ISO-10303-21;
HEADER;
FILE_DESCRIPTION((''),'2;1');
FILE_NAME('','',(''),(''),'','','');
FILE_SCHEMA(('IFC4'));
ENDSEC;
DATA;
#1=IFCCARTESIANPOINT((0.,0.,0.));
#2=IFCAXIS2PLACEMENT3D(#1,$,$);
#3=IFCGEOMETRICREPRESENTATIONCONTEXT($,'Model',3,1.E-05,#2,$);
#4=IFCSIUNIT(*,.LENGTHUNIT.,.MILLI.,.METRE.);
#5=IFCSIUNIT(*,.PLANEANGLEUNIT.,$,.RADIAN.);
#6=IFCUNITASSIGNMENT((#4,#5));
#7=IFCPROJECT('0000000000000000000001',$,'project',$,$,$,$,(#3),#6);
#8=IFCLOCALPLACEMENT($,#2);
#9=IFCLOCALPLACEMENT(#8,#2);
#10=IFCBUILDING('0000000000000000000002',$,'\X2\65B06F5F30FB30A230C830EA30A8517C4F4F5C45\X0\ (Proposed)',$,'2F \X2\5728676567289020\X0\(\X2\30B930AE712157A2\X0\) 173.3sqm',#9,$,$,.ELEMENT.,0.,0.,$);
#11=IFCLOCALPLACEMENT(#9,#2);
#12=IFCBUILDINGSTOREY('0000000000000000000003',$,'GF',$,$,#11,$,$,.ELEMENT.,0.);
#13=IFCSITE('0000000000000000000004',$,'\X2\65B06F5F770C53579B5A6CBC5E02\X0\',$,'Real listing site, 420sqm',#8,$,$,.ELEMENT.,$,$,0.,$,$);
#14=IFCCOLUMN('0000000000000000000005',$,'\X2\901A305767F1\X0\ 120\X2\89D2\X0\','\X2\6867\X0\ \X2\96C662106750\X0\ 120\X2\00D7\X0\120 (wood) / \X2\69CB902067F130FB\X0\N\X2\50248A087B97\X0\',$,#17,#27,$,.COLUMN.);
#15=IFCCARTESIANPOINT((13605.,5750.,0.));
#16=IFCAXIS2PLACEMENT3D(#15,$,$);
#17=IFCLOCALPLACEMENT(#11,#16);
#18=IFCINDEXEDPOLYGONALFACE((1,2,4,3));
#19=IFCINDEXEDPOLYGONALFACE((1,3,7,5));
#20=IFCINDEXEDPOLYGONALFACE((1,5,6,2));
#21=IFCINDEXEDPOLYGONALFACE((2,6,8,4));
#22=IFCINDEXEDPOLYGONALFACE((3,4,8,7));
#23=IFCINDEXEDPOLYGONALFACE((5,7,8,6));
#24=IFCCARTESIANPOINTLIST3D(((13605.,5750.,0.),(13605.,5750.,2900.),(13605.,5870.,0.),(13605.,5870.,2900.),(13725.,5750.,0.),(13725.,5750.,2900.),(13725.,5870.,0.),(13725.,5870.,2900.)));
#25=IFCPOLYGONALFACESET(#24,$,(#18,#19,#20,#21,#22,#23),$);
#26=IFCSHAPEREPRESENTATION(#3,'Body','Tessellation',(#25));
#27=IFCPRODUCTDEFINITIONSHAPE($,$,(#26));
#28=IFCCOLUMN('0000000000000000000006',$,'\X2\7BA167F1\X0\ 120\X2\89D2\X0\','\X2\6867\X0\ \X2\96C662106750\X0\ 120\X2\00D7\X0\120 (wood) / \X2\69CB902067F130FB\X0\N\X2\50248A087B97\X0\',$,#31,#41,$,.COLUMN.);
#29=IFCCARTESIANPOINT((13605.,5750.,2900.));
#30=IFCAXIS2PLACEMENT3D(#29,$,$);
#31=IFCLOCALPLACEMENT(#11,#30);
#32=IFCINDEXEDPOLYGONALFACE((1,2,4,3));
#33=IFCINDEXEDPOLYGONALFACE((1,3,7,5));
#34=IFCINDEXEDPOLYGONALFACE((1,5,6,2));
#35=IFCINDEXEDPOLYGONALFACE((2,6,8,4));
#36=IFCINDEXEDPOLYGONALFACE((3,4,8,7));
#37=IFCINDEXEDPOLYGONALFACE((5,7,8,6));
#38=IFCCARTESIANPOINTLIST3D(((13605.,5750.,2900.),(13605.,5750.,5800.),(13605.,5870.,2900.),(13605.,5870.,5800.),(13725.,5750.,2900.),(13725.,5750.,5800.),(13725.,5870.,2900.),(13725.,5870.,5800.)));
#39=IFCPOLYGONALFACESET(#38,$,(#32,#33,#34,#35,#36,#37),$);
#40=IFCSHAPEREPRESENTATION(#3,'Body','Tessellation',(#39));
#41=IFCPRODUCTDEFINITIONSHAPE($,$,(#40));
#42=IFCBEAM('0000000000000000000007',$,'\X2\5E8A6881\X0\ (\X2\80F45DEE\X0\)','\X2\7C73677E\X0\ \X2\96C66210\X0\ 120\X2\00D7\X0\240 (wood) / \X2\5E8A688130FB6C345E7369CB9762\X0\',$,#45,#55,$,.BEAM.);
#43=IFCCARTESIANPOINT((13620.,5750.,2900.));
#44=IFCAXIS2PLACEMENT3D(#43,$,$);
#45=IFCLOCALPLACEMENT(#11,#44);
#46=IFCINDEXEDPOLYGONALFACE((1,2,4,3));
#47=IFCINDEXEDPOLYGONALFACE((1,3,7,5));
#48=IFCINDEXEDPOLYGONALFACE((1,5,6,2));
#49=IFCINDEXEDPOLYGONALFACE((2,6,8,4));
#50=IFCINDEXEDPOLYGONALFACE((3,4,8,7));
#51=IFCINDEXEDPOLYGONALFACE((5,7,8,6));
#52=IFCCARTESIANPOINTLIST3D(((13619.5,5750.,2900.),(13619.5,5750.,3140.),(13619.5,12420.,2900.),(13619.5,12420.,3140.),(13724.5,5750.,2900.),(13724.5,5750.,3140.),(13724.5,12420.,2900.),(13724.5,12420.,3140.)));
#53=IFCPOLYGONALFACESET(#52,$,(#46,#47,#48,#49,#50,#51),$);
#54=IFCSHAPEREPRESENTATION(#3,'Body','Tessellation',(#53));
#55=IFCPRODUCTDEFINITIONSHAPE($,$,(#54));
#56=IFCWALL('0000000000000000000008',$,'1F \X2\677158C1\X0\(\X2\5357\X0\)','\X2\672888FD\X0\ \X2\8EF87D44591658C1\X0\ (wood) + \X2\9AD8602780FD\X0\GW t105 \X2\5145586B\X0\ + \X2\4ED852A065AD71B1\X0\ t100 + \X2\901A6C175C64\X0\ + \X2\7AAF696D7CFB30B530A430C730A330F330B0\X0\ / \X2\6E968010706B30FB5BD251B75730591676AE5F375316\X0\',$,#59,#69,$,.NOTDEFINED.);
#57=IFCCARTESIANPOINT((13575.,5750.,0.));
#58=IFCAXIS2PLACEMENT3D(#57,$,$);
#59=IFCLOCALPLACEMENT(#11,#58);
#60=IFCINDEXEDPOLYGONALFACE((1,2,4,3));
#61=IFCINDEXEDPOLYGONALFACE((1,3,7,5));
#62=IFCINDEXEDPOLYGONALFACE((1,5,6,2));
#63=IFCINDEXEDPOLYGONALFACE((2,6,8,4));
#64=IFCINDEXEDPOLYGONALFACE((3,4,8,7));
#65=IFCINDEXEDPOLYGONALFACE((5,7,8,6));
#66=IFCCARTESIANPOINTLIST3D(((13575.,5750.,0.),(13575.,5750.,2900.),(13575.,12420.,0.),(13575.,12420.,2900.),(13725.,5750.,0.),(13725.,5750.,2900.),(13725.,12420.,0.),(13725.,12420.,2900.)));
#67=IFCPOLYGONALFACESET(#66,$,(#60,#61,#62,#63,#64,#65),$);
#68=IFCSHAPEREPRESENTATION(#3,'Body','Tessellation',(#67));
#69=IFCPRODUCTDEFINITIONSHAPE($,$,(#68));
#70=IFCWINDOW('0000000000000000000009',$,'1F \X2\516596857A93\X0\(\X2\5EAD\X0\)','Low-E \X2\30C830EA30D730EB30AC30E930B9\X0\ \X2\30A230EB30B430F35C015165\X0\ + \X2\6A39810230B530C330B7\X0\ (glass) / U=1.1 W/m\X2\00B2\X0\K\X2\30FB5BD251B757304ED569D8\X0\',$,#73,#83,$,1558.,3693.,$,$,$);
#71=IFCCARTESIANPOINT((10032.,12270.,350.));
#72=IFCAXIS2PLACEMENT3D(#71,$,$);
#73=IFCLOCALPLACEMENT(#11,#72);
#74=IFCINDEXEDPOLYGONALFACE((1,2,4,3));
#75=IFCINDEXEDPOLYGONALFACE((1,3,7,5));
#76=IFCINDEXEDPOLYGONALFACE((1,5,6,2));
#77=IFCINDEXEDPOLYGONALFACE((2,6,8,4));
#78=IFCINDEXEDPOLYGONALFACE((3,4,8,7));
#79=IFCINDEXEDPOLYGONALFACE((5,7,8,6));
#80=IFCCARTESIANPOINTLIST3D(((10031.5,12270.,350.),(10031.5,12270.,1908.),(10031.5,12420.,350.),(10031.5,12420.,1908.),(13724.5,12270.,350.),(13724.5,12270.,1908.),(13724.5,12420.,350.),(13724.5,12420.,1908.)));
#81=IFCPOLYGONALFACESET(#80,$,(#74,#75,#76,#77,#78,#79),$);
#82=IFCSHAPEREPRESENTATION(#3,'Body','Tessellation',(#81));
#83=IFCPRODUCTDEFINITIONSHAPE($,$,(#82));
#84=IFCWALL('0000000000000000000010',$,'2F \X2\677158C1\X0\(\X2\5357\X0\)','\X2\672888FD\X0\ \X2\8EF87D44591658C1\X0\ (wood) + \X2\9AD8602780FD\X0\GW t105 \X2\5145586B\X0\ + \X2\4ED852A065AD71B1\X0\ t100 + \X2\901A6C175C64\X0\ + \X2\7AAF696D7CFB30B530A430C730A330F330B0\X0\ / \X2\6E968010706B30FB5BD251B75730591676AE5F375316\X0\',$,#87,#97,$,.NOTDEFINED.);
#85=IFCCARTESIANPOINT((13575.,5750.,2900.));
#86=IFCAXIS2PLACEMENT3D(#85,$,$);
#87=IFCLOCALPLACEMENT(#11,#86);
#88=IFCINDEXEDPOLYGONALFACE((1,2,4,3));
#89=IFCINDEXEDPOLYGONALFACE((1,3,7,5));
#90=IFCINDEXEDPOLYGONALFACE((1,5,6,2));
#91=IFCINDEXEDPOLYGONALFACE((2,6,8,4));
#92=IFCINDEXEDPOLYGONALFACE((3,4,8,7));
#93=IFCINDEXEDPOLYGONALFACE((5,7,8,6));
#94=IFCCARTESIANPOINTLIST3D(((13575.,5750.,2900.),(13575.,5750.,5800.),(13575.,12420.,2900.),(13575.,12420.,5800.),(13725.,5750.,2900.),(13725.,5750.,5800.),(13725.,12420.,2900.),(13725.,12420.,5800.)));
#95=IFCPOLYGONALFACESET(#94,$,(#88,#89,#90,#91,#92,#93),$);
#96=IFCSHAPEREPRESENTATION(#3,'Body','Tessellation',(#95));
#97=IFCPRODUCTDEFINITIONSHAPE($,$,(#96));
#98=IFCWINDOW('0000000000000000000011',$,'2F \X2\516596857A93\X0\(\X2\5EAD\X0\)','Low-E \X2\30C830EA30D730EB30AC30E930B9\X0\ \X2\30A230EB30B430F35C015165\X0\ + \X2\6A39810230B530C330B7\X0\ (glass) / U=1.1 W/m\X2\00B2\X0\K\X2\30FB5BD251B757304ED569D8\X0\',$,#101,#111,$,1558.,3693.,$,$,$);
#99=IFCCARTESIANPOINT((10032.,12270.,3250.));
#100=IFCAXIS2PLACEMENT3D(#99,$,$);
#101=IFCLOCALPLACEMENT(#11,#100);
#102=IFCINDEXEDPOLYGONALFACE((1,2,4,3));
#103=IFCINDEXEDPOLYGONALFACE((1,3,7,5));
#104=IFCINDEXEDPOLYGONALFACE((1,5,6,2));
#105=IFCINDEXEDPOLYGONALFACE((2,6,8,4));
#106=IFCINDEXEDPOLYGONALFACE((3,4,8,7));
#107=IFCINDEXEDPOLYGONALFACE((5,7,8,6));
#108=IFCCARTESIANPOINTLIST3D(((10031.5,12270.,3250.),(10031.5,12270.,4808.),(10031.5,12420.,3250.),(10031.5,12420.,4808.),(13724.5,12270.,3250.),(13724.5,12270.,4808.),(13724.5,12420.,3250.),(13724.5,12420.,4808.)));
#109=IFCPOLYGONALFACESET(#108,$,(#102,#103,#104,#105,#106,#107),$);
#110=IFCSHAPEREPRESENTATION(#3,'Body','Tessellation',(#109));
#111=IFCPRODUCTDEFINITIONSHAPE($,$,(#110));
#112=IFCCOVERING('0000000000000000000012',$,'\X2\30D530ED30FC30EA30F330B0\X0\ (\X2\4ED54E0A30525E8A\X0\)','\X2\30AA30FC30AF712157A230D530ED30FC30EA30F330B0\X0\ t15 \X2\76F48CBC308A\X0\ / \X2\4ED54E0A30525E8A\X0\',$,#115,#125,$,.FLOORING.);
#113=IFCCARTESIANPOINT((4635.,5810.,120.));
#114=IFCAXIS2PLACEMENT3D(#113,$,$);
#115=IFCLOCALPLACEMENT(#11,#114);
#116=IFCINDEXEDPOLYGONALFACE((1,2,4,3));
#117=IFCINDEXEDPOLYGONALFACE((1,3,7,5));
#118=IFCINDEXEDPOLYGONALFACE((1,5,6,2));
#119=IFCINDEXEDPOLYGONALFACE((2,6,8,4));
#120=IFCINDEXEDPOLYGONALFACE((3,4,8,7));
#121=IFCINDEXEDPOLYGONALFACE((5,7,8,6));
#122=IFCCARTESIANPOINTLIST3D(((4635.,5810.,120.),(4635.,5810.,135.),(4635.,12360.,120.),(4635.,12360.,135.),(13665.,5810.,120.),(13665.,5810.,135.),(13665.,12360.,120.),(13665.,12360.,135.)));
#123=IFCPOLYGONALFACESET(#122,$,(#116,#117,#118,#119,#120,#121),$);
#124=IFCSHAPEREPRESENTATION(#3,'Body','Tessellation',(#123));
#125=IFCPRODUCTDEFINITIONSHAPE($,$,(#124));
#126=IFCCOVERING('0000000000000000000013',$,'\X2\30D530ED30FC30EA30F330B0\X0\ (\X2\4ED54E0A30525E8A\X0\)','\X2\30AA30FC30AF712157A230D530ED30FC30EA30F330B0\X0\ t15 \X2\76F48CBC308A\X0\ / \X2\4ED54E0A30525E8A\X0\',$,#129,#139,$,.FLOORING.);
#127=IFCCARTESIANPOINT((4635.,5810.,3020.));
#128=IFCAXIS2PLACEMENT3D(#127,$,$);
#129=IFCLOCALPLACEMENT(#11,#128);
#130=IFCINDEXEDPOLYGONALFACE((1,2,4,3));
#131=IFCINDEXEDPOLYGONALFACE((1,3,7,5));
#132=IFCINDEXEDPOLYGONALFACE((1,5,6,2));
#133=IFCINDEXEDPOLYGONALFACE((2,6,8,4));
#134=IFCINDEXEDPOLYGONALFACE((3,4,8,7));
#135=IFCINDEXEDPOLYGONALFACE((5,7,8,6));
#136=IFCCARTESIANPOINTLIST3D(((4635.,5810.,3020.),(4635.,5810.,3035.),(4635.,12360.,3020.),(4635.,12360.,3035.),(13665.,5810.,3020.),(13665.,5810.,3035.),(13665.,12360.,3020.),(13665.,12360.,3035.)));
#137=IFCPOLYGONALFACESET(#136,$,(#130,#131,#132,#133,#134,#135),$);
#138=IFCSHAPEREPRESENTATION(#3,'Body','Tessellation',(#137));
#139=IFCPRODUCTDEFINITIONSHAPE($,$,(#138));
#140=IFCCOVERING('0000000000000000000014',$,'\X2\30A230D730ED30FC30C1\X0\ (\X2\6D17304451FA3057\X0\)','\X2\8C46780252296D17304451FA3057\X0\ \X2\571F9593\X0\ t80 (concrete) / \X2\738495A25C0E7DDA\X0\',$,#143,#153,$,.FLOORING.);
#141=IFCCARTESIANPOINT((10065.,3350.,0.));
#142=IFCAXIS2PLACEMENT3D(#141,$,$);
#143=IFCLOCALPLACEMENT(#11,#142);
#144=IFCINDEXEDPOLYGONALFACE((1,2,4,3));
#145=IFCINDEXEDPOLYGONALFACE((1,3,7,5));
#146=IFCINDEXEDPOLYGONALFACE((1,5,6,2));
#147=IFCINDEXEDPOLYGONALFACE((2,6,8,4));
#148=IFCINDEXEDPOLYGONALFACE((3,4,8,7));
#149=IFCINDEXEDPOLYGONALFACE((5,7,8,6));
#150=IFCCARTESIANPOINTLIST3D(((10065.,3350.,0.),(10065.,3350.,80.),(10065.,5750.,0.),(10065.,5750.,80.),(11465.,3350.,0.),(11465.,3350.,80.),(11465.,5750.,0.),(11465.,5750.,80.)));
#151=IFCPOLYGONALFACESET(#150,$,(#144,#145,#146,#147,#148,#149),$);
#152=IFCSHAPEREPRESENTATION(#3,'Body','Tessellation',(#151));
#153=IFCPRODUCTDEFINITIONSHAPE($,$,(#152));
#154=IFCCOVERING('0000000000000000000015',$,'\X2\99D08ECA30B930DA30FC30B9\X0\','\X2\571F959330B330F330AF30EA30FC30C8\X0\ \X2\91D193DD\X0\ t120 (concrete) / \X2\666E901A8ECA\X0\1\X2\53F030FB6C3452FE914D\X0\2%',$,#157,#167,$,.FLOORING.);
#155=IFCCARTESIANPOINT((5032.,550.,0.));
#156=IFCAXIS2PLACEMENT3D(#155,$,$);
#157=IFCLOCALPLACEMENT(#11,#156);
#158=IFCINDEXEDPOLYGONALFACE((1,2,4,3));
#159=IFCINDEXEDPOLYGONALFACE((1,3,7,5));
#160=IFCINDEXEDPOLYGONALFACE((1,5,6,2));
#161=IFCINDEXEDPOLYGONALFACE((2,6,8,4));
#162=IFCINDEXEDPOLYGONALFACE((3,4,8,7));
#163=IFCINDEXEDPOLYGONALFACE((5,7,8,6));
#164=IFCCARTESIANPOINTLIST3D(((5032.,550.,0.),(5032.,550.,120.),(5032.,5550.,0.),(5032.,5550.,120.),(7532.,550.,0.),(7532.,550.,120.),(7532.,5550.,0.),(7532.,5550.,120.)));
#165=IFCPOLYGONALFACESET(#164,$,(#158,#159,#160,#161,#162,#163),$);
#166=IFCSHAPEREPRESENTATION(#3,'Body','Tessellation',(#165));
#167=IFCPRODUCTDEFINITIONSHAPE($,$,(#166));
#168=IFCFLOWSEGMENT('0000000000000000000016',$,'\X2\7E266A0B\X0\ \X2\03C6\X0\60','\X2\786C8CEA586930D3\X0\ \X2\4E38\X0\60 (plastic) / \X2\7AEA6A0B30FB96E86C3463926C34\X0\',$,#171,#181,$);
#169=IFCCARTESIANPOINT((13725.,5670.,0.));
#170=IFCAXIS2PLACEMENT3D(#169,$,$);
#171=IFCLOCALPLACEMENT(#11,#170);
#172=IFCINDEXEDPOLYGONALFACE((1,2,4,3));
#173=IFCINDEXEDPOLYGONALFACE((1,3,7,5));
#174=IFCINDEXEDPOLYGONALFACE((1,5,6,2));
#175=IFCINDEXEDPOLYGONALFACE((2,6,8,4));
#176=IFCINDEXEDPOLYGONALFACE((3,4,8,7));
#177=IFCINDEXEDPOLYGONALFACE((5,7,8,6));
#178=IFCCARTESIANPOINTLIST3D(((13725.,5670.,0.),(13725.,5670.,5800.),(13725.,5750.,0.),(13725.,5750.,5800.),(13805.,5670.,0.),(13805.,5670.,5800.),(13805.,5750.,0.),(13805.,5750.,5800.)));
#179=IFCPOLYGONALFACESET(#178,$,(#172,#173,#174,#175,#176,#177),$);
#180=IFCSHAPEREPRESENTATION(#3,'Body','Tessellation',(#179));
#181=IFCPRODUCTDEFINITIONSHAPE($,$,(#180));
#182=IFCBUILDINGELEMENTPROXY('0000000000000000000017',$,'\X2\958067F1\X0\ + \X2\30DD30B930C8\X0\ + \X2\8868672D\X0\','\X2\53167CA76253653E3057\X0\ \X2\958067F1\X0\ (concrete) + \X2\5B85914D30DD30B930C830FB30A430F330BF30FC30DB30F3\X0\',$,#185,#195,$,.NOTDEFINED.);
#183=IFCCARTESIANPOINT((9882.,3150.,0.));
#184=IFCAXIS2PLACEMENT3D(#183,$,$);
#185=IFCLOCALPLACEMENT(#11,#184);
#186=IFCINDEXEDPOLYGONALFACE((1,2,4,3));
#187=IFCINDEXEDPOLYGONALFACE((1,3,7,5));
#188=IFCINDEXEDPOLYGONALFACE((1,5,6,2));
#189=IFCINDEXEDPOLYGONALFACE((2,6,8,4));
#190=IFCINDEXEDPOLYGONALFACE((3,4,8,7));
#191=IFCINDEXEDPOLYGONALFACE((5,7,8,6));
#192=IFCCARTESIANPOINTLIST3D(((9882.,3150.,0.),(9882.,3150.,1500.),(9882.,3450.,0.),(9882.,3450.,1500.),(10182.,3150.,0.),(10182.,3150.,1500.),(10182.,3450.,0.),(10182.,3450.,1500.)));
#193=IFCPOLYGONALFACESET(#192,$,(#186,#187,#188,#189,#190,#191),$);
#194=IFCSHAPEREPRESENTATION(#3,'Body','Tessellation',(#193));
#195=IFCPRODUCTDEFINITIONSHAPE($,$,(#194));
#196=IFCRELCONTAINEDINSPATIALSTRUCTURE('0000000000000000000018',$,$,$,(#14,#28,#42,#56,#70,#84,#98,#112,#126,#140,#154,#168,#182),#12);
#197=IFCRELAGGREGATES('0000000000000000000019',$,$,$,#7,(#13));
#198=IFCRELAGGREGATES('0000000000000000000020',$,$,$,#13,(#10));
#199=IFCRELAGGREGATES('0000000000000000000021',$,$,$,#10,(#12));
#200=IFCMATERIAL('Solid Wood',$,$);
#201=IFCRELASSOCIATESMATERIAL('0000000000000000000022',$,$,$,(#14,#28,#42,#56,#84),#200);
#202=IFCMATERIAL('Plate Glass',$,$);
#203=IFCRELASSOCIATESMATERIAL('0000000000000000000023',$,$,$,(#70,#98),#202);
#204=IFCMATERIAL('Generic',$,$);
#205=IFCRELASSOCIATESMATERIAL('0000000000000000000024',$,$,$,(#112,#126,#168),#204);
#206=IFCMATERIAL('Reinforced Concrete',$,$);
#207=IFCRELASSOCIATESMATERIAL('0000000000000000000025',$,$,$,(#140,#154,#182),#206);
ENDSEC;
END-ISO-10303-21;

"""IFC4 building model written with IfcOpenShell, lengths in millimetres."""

from ifc_helpers import new_model, si_unit, frame, frame_2d, origin, place, context, project, spatial, rectangle, extrude, material, element, fill, save


model = new_model("IFC4")

# Units and contexts
model_context = context("Model", 3, precision=1e-05, world=origin())
ifc_project = project(units=[si_unit("LENGTHUNIT", "METRE", prefix="MILLI"), si_unit("PLANEANGLEUNIT", "RADIAN")], contexts=[model_context])

# Site, building, storey
site_placement = place(None, origin())
site = spatial("IfcSite", under=ifc_project, at=site_placement, Name="新潟県南魚沼市", ObjectType="Real listing site, 420sqm", CompositionType="ELEMENT", RefElevation=0.0)
building_placement = place(site_placement, origin())
building = spatial("IfcBuilding", under=site, at=building_placement, Name="新潟・アトリエ兼住居 (Proposed)", ObjectType="2F 在来木造(スギ無垢) 173.3sqm", CompositionType="ELEMENT", ElevationOfRefHeight=0.0, ElevationOfTerrain=0.0)
storey_placement = place(building_placement, origin())
storey = spatial("IfcBuildingStorey", under=building, at=storey_placement, Name="GF", CompositionType="ELEMENT", Elevation=0.0)

# Columns
ifc_material_1 = material(Name="Solid Wood")
column_1_placement = place(storey_placement, frame((13605.0, 5750.0, 0.0)))
element("IfcColumn", 1, at=column_1_placement, inside=storey, material=ifc_material_1, Name="通し柱 120角", Description="桧 集成材 120×120 (wood) / 構造柱・N値計算", PredefinedType="COLUMN", context=model_context, shape_type="SweptSolid", body=[
    extrude(rectangle(XDim=120.0, YDim=120.0, at=frame_2d((60.0, 60.0))), frame((13605.0, 5750.0, 0.0)), (0.0, 0.0, 1.0), 2900.0),
])
column_2_placement = place(storey_placement, frame((13605.0, 5750.0, 2900.0)))
element("IfcColumn", 2, at=column_2_placement, inside=storey, material=ifc_material_1, Name="管柱 120角", Description="桧 集成材 120×120 (wood) / 構造柱・N値計算", PredefinedType="COLUMN", context=model_context, shape_type="SweptSolid", body=[
    extrude(rectangle(XDim=120.0, YDim=120.0, at=frame_2d((60.0, 60.0))), frame((13605.0, 5750.0, 2900.0)), (0.0, 0.0, 1.0), 2900.0),
])

# Beam
beam_1_placement = place(storey_placement, frame((13620.0, 5750.0, 2900.0)))
element("IfcBeam", 3, at=beam_1_placement, inside=storey, material=ifc_material_1, Name="床梁 (胴差)", Description="米松 集成 120×240 (wood) / 床梁・水平構面", PredefinedType="BEAM", context=model_context, shape_type="SweptSolid", body=[
    extrude(rectangle(XDim=105.0, YDim=6670.0, at=frame_2d((52.0, 3335.0))), frame((13620.0, 5750.0, 2900.0)), (0.0, 0.0, 1.0), 240.0),
])

# Wall, opening, window
wall_1_placement = place(storey_placement, frame((13575.0, 5750.0, 0.0)))
wall_1 = element("IfcWall", 4, at=wall_1_placement, inside=storey, material=ifc_material_1, Name="1F 東壁(南)", Description="木製 軸組外壁 (wood) + 高性能GW t105 充填 + 付加断熱 t100 + 通気層 + 窯業系サイディング / 準耐火・寒冷地外皮強化", PredefinedType="NOTDEFINED", context=model_context, shape_type="SweptSolid", body=[
    extrude(rectangle(XDim=150.0, YDim=6670.0, at=frame_2d((75.0, 3335.0))), frame((13575.0, 5750.0, 0.0)), (0.0, 0.0, 1.0), 2900.0),
])
opening_1_placement = place(storey_placement, frame((10032.0, 12270.0, 350.0)))
opening_1 = element("IfcOpeningElement", 5, at=opening_1_placement, cuts=wall_1, PredefinedType="NOTDEFINED", context=model_context, shape_type="SweptSolid", body=[
    extrude(rectangle(XDim=3693.0, YDim=150.0, at=frame_2d((1846.0, 75.0))), frame((10032.0, 12270.0, 350.0)), (0.0, 0.0, 1.0), 1558.0),
])
ifc_material_2 = material(Name="Plate Glass")
window_1_placement = place(storey_placement, frame((10032.0, 12270.0, 350.0)))
window_1 = element("IfcWindow", 6, at=window_1_placement, inside=storey, material=ifc_material_2, Name="1F 入隅窓(庭)", Description="Low-E トリプルガラス アルゴン封入 + 樹脂サッシ (glass) / U=1.1 W/m²K・寒冷地仕様", OverallHeight=1558.0, OverallWidth=3693.0, context=model_context, shape_type="SweptSolid", body=[
    extrude(rectangle(XDim=3693.0, YDim=150.0, at=frame_2d((1846.0, 75.0))), frame((10032.0, 12270.0, 350.0)), (0.0, 0.0, 1.0), 1558.0),
])
fill(opening_1, window_1)

# Wall, opening, window
wall_2_placement = place(storey_placement, frame((13575.0, 5750.0, 2900.0)))
wall_2 = element("IfcWall", 7, at=wall_2_placement, inside=storey, material=ifc_material_1, Name="2F 東壁(南)", Description="木製 軸組外壁 (wood) + 高性能GW t105 充填 + 付加断熱 t100 + 通気層 + 窯業系サイディング / 準耐火・寒冷地外皮強化", PredefinedType="NOTDEFINED", context=model_context, shape_type="SweptSolid", body=[
    extrude(rectangle(XDim=150.0, YDim=6670.0, at=frame_2d((75.0, 3335.0))), frame((13575.0, 5750.0, 2900.0)), (0.0, 0.0, 1.0), 2900.0),
])
opening_2_placement = place(storey_placement, frame((10032.0, 12270.0, 3250.0)))
opening_2 = element("IfcOpeningElement", 8, at=opening_2_placement, cuts=wall_2, PredefinedType="NOTDEFINED", context=model_context, shape_type="SweptSolid", body=[
    extrude(rectangle(XDim=3693.0, YDim=150.0, at=frame_2d((1846.0, 75.0))), frame((10032.0, 12270.0, 3250.0)), (0.0, 0.0, 1.0), 1558.0),
])
window_2_placement = place(storey_placement, frame((10032.0, 12270.0, 3250.0)))
window_2 = element("IfcWindow", 9, at=window_2_placement, inside=storey, material=ifc_material_2, Name="2F 入隅窓(庭)", Description="Low-E トリプルガラス アルゴン封入 + 樹脂サッシ (glass) / U=1.1 W/m²K・寒冷地仕様", OverallHeight=1558.0, OverallWidth=3693.0, context=model_context, shape_type="SweptSolid", body=[
    extrude(rectangle(XDim=3693.0, YDim=150.0, at=frame_2d((1846.0, 75.0))), frame((10032.0, 12270.0, 3250.0)), (0.0, 0.0, 1.0), 1558.0),
])
fill(opening_2, window_2)

# Coverings
ifc_material_3 = material(Name="Generic")
covering_1_placement = place(storey_placement, frame((4635.0, 5810.0, 120.0)))
element("IfcCovering", 10, at=covering_1_placement, inside=storey, material=ifc_material_3, Name="フローリング (仕上げ床)", Description="オーク無垢フローリング t15 直貼り / 仕上げ床", PredefinedType="FLOORING", context=model_context, shape_type="SweptSolid", body=[
    extrude(rectangle(XDim=9030.0, YDim=6550.0, at=frame_2d((4515.0, 3275.0))), frame((4635.0, 5810.0, 120.0)), (0.0, 0.0, 1.0), 15.0),
])
covering_2_placement = place(storey_placement, frame((4635.0, 5810.0, 3020.0)))
element("IfcCovering", 11, at=covering_2_placement, inside=storey, material=ifc_material_3, Name="フローリング (仕上げ床)", Description="オーク無垢フローリング t15 直貼り / 仕上げ床", PredefinedType="FLOORING", context=model_context, shape_type="SweptSolid", body=[
    extrude(rectangle(XDim=9030.0, YDim=6550.0, at=frame_2d((4515.0, 3275.0))), frame((4635.0, 5810.0, 3020.0)), (0.0, 0.0, 1.0), 15.0),
])
ifc_material_4 = material(Name="Reinforced Concrete")
covering_3_placement = place(storey_placement, frame((10065.0, 3350.0, 0.0)))
element("IfcCovering", 12, at=covering_3_placement, inside=storey, material=ifc_material_4, Name="アプローチ (洗い出し)", Description="豆砂利洗い出し 土間 t80 (concrete) / 玄関導線", PredefinedType="FLOORING", context=model_context, shape_type="SweptSolid", body=[
    extrude(rectangle(XDim=1400.0, YDim=2400.0, at=frame_2d((700.0, 1200.0))), frame((10065.0, 3350.0, 0.0)), (0.0, 0.0, 1.0), 80.0),
])
covering_4_placement = place(storey_placement, frame((5032.0, 550.0, 0.0)))
element("IfcCovering", 13, at=covering_4_placement, inside=storey, material=ifc_material_4, Name="駐車スペース", Description="土間コンクリート 金鏝 t120 (concrete) / 普通車1台・水勾配2%", PredefinedType="FLOORING", context=model_context, shape_type="SweptSolid", body=[
    extrude(rectangle(XDim=2500.0, YDim=5000.0, at=frame_2d((1250.0, 2500.0))), frame((5032.0, 550.0, 0.0)), (0.0, 0.0, 1.0), 120.0),
])

# Flow segment
flow_segment_placement = place(storey_placement, frame((13725.0, 5670.0, 0.0)))
element("IfcFlowSegment", 14, at=flow_segment_placement, inside=storey, material=ifc_material_3, Name="縦樋 φ60", Description="硬質塩ビ 丸60 (plastic) / 竪樋・雨水排水", context=model_context, shape_type="SweptSolid", body=[
    extrude(rectangle(XDim=80.0, YDim=80.0, at=frame_2d((40.0, 40.0))), frame((13725.0, 5670.0, 0.0)), (0.0, 0.0, 1.0), 5800.0),
])

# Building element proxy
proxy_placement = place(storey_placement, frame((9882.0, 3150.0, 0.0)))
element("IfcBuildingElementProxy", 15, at=proxy_placement, inside=storey, material=ifc_material_4, Name="門柱 + ポスト + 表札", Description="化粧打放し 門柱 (concrete) + 宅配ポスト・インターホン", PredefinedType="NOTDEFINED", context=model_context, shape_type="SweptSolid", body=[
    extrude(rectangle(XDim=300.0, YDim=300.0, at=frame_2d((150.0, 150.0))), frame((9882.0, 3150.0, 0.0)), (0.0, 0.0, 1.0), 1500.0),
])

save(model, "model.ifc")
